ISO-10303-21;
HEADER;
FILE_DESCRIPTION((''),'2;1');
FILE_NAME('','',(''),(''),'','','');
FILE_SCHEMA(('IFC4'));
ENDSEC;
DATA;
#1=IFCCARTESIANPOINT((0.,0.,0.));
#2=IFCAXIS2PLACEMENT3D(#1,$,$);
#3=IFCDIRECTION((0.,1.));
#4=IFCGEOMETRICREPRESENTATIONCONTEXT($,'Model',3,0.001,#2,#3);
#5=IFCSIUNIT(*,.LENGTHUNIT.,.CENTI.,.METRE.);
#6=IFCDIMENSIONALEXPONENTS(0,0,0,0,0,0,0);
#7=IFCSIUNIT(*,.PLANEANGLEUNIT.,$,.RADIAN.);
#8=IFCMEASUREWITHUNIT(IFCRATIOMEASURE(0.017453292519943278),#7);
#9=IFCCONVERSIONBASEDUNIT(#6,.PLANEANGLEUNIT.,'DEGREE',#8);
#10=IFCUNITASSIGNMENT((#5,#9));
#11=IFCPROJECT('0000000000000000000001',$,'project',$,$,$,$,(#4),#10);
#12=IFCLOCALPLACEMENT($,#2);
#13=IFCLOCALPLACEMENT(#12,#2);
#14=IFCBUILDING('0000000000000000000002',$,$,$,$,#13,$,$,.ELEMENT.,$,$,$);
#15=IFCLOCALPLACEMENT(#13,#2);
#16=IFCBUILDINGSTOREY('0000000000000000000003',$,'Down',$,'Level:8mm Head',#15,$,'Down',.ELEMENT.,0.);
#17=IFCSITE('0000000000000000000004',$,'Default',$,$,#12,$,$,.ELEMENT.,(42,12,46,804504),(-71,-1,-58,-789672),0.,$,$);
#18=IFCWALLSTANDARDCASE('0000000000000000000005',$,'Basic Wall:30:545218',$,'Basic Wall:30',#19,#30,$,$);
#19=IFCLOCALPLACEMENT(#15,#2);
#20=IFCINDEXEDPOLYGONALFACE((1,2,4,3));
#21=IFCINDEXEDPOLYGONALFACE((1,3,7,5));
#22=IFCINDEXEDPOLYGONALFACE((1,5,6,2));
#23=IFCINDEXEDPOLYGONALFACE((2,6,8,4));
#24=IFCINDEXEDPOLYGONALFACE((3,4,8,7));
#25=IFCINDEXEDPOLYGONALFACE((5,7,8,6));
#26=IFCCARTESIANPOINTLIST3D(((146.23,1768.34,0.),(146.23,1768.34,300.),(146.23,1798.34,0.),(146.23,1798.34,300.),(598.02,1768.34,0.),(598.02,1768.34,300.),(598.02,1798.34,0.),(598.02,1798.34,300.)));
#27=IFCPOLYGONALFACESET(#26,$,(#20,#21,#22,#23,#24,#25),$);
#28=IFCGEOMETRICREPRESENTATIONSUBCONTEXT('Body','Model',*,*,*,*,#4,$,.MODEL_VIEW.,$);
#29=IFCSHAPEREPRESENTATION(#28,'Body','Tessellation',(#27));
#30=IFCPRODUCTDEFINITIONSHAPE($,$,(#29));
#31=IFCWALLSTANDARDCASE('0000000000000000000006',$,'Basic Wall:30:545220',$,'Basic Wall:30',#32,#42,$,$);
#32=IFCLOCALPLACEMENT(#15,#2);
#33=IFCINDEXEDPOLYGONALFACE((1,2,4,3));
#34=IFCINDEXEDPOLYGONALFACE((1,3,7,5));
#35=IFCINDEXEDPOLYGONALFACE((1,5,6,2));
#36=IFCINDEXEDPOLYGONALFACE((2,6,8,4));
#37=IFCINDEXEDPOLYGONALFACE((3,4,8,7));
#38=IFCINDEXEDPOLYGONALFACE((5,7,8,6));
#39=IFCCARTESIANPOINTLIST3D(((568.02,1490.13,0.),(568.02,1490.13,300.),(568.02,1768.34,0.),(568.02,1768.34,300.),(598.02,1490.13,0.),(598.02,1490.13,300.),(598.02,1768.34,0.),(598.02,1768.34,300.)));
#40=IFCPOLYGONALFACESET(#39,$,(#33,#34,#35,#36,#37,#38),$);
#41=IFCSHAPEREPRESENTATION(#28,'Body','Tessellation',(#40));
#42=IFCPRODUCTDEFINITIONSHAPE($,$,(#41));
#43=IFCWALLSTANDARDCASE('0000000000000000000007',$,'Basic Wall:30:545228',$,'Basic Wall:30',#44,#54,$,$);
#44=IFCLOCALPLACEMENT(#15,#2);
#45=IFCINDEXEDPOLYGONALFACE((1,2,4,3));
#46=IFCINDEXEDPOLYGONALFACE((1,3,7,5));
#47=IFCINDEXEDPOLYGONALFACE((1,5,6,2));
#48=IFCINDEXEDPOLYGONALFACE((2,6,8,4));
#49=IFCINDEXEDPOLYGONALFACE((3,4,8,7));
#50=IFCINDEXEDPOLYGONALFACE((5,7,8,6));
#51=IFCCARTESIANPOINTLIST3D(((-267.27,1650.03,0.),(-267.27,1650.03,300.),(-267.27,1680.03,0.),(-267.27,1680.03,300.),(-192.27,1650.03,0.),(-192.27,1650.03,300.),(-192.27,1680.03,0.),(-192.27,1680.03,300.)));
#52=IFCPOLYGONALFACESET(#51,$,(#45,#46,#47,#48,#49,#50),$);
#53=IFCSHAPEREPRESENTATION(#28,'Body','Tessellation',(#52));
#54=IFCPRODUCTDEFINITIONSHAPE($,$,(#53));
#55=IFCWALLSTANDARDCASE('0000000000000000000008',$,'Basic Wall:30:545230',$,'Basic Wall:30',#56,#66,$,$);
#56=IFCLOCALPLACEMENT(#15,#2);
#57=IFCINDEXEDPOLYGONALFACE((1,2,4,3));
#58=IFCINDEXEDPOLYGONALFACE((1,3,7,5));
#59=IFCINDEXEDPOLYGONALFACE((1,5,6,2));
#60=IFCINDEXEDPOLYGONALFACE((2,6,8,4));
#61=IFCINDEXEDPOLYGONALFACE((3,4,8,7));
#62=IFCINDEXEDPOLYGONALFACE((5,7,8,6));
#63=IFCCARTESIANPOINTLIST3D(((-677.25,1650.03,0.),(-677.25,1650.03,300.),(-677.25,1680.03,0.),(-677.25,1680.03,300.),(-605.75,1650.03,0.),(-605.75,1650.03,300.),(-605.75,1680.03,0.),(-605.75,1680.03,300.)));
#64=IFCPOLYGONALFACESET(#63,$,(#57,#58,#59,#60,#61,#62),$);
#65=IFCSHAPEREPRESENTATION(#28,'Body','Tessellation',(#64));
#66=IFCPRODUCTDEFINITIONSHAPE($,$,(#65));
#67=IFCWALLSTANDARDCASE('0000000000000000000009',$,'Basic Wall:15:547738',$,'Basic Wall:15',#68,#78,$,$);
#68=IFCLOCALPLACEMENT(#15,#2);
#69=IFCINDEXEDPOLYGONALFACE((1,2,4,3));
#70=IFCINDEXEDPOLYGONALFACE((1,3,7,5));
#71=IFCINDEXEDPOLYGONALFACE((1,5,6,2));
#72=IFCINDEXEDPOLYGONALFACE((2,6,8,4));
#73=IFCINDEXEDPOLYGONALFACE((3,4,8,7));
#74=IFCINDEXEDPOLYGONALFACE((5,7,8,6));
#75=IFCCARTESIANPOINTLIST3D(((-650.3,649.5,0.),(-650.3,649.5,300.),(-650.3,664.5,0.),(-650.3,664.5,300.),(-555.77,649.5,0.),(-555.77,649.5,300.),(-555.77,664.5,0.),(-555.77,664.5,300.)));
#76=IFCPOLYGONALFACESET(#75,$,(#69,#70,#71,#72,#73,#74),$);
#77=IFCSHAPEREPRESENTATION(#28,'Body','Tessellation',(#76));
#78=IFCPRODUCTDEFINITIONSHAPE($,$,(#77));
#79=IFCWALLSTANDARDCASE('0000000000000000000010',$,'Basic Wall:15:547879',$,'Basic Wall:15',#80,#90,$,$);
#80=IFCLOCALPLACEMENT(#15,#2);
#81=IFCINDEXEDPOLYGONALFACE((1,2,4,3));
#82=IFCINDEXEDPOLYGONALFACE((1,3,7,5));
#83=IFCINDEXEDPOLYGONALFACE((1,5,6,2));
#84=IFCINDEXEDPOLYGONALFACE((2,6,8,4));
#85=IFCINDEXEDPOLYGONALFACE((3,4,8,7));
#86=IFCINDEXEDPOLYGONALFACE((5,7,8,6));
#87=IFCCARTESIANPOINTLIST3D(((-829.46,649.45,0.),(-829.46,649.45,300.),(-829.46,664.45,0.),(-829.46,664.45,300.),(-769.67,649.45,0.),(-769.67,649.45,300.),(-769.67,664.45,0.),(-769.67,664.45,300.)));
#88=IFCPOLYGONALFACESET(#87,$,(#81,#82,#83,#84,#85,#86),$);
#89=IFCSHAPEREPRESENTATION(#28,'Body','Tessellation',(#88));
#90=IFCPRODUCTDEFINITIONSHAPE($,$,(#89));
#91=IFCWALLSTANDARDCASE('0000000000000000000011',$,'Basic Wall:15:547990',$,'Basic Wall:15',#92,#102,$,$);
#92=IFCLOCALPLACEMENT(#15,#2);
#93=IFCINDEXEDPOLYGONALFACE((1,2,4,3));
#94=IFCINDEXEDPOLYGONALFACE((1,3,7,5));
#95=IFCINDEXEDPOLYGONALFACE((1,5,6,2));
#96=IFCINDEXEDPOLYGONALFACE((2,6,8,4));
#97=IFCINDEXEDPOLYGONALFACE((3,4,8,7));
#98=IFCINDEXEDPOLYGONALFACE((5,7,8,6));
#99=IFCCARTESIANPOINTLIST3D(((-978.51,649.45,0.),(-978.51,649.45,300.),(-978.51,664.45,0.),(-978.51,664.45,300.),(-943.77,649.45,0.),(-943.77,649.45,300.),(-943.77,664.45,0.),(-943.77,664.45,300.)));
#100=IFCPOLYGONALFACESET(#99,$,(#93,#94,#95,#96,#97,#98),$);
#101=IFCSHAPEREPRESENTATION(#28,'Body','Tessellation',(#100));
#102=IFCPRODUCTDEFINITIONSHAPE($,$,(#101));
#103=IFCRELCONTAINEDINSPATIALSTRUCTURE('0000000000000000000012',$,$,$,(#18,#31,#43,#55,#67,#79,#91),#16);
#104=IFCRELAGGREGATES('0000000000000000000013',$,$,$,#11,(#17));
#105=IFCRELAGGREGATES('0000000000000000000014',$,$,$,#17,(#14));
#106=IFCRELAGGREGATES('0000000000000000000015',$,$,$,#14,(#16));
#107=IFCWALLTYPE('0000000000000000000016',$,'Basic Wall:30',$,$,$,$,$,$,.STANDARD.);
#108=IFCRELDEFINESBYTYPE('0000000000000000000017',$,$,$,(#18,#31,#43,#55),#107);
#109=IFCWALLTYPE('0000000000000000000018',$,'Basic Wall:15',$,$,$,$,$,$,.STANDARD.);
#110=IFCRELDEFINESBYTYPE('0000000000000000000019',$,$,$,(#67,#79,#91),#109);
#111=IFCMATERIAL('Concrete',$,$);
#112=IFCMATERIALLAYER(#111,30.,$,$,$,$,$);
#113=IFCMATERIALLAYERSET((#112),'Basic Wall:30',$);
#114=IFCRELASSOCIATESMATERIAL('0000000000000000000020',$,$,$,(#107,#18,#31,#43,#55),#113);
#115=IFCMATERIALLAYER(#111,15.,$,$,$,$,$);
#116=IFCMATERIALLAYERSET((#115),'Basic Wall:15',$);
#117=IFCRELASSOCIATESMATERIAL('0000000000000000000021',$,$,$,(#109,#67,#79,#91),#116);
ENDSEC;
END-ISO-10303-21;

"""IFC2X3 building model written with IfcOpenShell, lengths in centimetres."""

from ifc_helpers import new_model, entity, si_unit, converted_unit, direction, frame, frame_2d, origin, place, context, subcontext, project, spatial, rectangle, extrude, material, layer, layer_set, layer_usage, type_object, element, save


model = new_model("IFC2X3")

# Units and contexts
model_context = context("Model", 3, precision=0.001, world=origin(), true_north=direction((0.0, 1.0)))
body_context = subcontext(model_context, "Body", "Model", "MODEL_VIEW")
ifc_project = project(units=[si_unit("LENGTHUNIT", "METRE", prefix="CENTI"), converted_unit("PLANEANGLEUNIT", "DEGREE", entity("IfcRatioMeasure", 0.017453292519943278), si_unit("PLANEANGLEUNIT", "RADIAN"), dimensions=[0, 0, 0, 0, 0, 0, 0])], contexts=[model_context])

# Site, building, storey
site_placement = place(None, origin())
site = spatial("IfcSite", under=ifc_project, at=site_placement, Name="Default", CompositionType="ELEMENT", RefLatitude=(42, 12, 46, 804504), RefLongitude=(-71, -1, -58, -789672), RefElevation=0.0)
building_placement = place(site_placement, origin())
building = spatial("IfcBuilding", under=site, at=building_placement, CompositionType="ELEMENT")
storey_placement = place(building_placement, origin())
storey = spatial("IfcBuildingStorey", under=building, at=storey_placement, Name="Down", ObjectType="Level:8mm Head", LongName="Down", CompositionType="ELEMENT", Elevation=0.0)

# Shared definitions
ifc_material = material(Name="Concrete")

# Walls
ifc_layer_1 = layer(ifc_material, 30.0)
ifc_layer_set_1 = layer_set([ifc_layer_1], Name="Basic Wall:30")
ifc_layer_usage_1 = layer_usage(ifc_layer_set_1, "AXIS2", "NEGATIVE", 15.0)
wall_type_1 = type_object("IfcWallType", Name="Basic Wall:30", PredefinedType="STANDARD", material=ifc_layer_set_1)
wall_1_placement = place(storey_placement, frame((146.23, 1783.34, 0.0)))
element("IfcWallStandardCase", 1, at=wall_1_placement, inside=storey, type_object=wall_type_1, material=ifc_layer_usage_1, Name="Basic Wall:30:545218", ObjectType="Basic Wall:30", context=body_context, shape_type="SweptSolid", body=[
    extrude(rectangle(XDim=451.79, YDim=30.0, at=frame_2d((225.89, 0.0), x_axis=(-1.0, 0.0))), origin(), (0.0, 0.0, 1.0), 300.0),
])
ifc_layer_usage_2 = layer_usage(ifc_layer_set_1, "AXIS2", "NEGATIVE", 15.0)
wall_2_placement = place(storey_placement, frame((583.02, 1768.34, 0.0), z_axis=(0.0, 0.0, 1.0), x_axis=(0.0, -1.0, 0.0)))
element("IfcWallStandardCase", 2, at=wall_2_placement, inside=storey, type_object=wall_type_1, material=ifc_layer_usage_2, Name="Basic Wall:30:545220", ObjectType="Basic Wall:30", context=body_context, shape_type="SweptSolid", body=[
    extrude(rectangle(XDim=278.21, YDim=30.0, at=frame_2d((139.11, 0.0), x_axis=(-1.0, 0.0))), origin(), (0.0, 0.0, 1.0), 300.0),
])
ifc_layer_usage_3 = layer_usage(ifc_layer_set_1, "AXIS2", "NEGATIVE", 15.0)
wall_3_placement = place(storey_placement, frame((-192.27, 1665.03, 0.0), z_axis=(0.0, 0.0, 1.0), x_axis=(-1.0, 0.0, 0.0)))
element("IfcWallStandardCase", 3, at=wall_3_placement, inside=storey, type_object=wall_type_1, material=ifc_layer_usage_3, Name="Basic Wall:30:545228", ObjectType="Basic Wall:30", context=body_context, shape_type="SweptSolid", body=[
    extrude(rectangle(XDim=75.0, YDim=30.0, at=frame_2d((37.5, 0.0), x_axis=(-1.0, 0.0))), origin(), (0.0, 0.0, 1.0), 300.0),
])
ifc_layer_usage_4 = layer_usage(ifc_layer_set_1, "AXIS2", "NEGATIVE", 15.0)
wall_4_placement = place(storey_placement, frame((-605.75, 1665.03, 0.0), z_axis=(0.0, 0.0, 1.0), x_axis=(-1.0, 0.0, 0.0)))
element("IfcWallStandardCase", 4, at=wall_4_placement, inside=storey, type_object=wall_type_1, material=ifc_layer_usage_4, Name="Basic Wall:30:545230", ObjectType="Basic Wall:30", context=body_context, shape_type="SweptSolid", body=[
    extrude(rectangle(XDim=71.5, YDim=30.0, at=frame_2d((35.75, 0.0), x_axis=(-1.0, 0.0))), origin(), (0.0, 0.0, 1.0), 300.0),
])
ifc_layer_2 = layer(ifc_material, 15.0)
ifc_layer_set_2 = layer_set([ifc_layer_2], Name="Basic Wall:15")
ifc_layer_usage_5 = layer_usage(ifc_layer_set_2, "AXIS2", "NEGATIVE", 7.5)
wall_type_2 = type_object("IfcWallType", Name="Basic Wall:15", PredefinedType="STANDARD", material=ifc_layer_set_2)
wall_5_placement = place(storey_placement, frame((-555.77, 657.0, 0.0), z_axis=(0.0, 0.0, 1.0), x_axis=(-1.0, 0.0, 0.0)))
element("IfcWallStandardCase", 5, at=wall_5_placement, inside=storey, type_object=wall_type_2, material=ifc_layer_usage_5, Name="Basic Wall:15:547738", ObjectType="Basic Wall:15", context=body_context, shape_type="SweptSolid", body=[
    extrude(rectangle(XDim=94.53, YDim=15.0, at=frame_2d((47.26, 0.0), x_axis=(-1.0, 0.0))), origin(), (0.0, 0.0, 1.0), 300.0),
])
ifc_layer_usage_6 = layer_usage(ifc_layer_set_2, "AXIS2", "POSITIVE", -7.5)
wall_6_placement = place(storey_placement, frame((-769.67, 656.95, 0.0), z_axis=(0.0, 0.0, 1.0), x_axis=(-1.0, 0.0, 0.0)))
element("IfcWallStandardCase", 6, at=wall_6_placement, inside=storey, type_object=wall_type_2, material=ifc_layer_usage_6, Name="Basic Wall:15:547879", ObjectType="Basic Wall:15", context=body_context, shape_type="SweptSolid", body=[
    extrude(rectangle(XDim=59.79, YDim=15.0, at=frame_2d((29.89, 0.0), x_axis=(-1.0, 0.0))), origin(), (0.0, 0.0, 1.0), 300.0),
])
ifc_layer_usage_7 = layer_usage(ifc_layer_set_2, "AXIS2", "POSITIVE", -7.5)
wall_7_placement = place(storey_placement, frame((-943.77, 656.95, 0.0), z_axis=(0.0, 0.0, 1.0), x_axis=(-1.0, 0.0, 0.0)))
element("IfcWallStandardCase", 7, at=wall_7_placement, inside=storey, type_object=wall_type_2, material=ifc_layer_usage_7, Name="Basic Wall:15:547990", ObjectType="Basic Wall:15", context=body_context, shape_type="SweptSolid", body=[
    extrude(rectangle(XDim=34.74, YDim=15.0, at=frame_2d((17.37, 0.0), x_axis=(-1.0, 0.0))), origin(), (0.0, 0.0, 1.0), 300.0),
])

save(model, "model.ifc")
